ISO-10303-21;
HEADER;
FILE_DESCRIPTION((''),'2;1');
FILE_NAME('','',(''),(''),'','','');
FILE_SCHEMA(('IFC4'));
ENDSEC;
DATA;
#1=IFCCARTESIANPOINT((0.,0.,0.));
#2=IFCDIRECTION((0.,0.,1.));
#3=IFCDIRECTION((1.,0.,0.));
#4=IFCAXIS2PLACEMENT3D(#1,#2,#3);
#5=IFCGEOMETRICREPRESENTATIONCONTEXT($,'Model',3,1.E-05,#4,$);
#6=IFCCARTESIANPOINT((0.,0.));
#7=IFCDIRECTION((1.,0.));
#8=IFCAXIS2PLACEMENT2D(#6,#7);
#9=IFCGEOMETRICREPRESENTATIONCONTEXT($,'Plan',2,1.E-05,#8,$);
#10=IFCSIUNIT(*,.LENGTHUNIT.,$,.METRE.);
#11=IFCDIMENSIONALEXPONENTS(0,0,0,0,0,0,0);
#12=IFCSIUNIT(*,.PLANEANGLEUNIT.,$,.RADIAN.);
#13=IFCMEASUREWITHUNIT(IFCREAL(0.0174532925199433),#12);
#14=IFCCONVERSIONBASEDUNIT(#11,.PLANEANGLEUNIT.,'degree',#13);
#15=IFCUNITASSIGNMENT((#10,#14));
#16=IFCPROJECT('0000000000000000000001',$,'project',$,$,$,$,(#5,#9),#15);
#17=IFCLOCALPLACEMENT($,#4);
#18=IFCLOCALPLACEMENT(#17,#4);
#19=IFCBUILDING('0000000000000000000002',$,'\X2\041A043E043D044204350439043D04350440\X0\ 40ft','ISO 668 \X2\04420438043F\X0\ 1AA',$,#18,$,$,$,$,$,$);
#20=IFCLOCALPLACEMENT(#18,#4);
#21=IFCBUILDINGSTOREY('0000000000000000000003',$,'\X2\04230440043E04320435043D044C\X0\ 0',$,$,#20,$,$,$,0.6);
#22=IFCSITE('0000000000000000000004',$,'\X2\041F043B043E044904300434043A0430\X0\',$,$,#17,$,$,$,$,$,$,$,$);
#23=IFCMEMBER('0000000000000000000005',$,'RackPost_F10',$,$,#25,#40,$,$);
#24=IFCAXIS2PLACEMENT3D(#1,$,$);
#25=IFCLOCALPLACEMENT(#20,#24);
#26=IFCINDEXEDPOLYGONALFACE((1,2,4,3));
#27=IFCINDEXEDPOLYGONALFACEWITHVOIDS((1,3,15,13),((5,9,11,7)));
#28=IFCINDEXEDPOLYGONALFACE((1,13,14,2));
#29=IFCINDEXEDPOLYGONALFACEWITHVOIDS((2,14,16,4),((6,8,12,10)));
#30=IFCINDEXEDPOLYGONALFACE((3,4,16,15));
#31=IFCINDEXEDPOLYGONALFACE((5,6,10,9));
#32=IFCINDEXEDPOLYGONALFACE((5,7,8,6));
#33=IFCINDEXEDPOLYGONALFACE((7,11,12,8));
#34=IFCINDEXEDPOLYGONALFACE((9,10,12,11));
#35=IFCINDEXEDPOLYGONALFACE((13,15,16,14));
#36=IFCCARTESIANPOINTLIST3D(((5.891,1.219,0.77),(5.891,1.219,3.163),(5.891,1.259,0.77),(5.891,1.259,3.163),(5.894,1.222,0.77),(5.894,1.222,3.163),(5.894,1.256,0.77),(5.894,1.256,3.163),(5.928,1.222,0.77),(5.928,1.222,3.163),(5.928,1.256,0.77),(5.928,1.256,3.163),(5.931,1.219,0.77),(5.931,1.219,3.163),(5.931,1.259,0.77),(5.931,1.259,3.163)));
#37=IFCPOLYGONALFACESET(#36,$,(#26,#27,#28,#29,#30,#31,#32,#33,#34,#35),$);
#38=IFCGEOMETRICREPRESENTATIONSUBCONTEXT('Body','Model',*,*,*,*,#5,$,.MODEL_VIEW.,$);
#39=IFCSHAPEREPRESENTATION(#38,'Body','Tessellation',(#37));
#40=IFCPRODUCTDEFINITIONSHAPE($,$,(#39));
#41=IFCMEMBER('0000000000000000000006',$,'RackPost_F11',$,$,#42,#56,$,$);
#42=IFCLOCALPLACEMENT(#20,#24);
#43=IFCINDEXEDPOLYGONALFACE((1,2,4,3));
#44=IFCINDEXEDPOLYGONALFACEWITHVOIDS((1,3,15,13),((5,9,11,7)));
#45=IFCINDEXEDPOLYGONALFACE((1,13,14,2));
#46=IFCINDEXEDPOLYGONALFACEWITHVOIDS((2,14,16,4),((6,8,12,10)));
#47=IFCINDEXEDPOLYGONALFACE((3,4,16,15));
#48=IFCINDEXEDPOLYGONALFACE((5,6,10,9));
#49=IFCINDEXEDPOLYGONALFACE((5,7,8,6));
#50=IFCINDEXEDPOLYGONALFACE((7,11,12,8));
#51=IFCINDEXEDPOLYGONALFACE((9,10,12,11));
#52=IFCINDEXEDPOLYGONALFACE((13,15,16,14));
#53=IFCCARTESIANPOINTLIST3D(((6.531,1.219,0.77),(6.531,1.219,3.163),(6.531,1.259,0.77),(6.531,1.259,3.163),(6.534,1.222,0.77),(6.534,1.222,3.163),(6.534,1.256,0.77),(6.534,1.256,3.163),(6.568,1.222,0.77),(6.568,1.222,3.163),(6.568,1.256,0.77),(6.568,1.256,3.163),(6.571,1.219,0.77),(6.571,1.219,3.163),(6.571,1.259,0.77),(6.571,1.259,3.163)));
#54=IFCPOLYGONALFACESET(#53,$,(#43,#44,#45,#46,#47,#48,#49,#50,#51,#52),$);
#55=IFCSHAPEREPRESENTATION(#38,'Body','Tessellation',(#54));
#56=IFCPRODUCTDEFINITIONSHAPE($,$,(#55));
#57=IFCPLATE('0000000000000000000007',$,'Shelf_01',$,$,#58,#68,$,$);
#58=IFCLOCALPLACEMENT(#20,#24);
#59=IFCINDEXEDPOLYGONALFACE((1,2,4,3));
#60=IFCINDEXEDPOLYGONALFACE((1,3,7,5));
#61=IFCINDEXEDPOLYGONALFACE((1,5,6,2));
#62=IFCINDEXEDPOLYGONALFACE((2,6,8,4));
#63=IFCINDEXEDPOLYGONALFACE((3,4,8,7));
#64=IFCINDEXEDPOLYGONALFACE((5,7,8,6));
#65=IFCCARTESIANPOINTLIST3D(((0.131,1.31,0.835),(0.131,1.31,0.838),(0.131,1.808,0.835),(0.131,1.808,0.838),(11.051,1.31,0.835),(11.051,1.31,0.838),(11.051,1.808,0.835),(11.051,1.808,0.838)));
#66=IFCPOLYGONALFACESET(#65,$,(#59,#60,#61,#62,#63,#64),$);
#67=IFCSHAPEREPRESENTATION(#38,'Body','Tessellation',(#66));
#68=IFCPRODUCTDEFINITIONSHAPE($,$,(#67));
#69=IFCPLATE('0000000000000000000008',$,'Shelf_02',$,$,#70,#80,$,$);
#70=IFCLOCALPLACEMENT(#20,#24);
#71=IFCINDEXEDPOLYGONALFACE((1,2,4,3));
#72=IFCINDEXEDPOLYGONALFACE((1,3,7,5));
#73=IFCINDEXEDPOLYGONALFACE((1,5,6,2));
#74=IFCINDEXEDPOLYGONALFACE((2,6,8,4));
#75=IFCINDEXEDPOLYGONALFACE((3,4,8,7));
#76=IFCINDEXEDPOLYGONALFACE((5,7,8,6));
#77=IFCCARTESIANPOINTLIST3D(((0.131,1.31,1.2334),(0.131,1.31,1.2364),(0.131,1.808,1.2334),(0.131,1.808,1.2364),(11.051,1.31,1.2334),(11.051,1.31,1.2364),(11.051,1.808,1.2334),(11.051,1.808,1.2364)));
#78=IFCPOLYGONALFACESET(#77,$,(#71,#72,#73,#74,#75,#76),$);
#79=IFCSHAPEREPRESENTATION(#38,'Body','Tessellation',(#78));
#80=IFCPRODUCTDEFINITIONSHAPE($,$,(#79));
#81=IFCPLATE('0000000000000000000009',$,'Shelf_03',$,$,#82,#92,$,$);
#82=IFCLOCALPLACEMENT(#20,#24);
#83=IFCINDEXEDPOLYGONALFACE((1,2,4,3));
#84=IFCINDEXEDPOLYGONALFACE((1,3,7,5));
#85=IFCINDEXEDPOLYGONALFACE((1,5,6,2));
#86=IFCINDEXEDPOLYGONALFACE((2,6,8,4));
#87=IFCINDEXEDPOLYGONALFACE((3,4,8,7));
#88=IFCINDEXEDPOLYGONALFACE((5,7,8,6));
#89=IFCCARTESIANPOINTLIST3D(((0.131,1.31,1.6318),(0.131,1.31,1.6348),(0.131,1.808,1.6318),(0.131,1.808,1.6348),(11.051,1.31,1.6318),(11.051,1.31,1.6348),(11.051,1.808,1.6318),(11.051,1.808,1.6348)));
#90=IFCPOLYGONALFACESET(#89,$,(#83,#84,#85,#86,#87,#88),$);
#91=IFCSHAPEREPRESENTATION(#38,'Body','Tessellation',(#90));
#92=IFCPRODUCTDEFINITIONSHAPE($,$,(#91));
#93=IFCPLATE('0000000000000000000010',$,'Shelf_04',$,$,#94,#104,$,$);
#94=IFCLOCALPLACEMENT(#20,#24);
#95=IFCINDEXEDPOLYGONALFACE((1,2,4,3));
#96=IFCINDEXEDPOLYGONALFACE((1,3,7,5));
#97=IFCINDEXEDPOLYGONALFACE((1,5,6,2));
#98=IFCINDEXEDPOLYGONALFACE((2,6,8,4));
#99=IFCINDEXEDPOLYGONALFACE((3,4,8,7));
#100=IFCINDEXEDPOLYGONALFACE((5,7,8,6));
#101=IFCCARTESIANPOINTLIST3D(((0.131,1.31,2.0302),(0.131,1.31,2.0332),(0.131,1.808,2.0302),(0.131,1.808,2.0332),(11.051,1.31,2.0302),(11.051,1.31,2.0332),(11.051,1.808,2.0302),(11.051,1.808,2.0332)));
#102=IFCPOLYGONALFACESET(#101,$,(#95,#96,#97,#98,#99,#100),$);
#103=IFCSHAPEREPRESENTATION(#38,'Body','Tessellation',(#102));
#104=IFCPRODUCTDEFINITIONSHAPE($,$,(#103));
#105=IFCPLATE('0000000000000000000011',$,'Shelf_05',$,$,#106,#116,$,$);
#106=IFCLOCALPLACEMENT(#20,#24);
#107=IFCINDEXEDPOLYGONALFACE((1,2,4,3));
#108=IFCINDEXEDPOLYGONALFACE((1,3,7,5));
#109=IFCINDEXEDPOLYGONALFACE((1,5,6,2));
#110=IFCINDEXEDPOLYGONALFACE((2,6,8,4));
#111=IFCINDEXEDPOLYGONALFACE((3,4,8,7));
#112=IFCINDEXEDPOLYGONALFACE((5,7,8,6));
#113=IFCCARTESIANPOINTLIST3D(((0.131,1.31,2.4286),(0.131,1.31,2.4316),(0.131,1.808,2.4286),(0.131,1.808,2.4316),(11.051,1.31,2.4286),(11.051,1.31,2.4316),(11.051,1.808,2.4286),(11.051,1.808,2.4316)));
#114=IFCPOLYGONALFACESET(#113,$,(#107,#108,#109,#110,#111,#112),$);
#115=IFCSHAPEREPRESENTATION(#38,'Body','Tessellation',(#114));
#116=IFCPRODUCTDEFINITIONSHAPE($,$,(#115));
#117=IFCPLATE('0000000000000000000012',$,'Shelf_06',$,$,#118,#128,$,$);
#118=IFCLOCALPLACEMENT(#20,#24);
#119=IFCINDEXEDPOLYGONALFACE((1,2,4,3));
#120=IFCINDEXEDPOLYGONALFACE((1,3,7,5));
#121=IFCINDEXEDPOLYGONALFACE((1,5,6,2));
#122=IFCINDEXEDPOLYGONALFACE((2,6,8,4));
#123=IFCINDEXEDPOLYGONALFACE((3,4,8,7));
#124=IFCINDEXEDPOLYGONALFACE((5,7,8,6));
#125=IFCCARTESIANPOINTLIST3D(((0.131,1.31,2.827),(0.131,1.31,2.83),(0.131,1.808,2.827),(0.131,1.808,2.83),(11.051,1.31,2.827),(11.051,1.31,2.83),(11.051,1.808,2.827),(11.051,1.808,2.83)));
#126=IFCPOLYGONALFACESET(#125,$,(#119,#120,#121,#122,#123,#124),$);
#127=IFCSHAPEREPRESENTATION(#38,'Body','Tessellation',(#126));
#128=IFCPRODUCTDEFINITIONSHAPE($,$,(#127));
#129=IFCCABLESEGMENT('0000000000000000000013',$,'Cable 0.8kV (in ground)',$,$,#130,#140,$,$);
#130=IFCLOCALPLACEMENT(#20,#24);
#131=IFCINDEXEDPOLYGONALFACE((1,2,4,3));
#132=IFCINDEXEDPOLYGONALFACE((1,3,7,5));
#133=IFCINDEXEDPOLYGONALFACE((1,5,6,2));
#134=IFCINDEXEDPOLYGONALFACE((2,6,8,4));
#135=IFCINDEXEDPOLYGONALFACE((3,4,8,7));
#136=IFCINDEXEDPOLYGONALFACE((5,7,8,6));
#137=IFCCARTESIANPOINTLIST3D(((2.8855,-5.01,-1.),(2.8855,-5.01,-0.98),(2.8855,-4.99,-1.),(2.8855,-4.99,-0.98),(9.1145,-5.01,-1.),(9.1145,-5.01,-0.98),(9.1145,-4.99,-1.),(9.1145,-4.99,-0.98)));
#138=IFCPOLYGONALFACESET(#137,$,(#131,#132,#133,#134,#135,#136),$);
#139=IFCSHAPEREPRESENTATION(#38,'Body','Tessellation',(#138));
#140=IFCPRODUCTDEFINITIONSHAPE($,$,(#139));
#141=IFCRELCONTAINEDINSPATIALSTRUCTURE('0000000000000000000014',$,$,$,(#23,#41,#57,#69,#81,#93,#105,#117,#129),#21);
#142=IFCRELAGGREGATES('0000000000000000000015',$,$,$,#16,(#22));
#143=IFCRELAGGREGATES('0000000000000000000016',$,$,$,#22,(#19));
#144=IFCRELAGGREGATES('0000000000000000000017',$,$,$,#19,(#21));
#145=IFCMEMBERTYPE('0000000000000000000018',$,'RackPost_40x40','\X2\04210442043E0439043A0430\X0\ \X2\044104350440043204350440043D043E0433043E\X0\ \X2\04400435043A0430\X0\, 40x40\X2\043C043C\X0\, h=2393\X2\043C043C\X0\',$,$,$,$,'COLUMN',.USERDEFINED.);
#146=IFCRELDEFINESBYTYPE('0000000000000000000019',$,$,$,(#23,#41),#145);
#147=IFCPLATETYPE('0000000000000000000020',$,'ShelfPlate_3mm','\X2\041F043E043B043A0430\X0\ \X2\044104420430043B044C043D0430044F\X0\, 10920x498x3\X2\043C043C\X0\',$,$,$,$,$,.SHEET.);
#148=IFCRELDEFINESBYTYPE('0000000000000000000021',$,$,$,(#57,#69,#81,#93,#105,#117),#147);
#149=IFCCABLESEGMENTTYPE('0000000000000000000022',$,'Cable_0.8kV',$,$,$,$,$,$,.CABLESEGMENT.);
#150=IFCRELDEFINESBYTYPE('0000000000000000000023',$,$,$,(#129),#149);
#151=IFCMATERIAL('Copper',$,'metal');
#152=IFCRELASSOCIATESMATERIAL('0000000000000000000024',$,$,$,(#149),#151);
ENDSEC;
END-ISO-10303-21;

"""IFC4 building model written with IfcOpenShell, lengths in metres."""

from ifc_helpers import new_model, entity, si_unit, converted_unit, frame, origin_with_axes, origin_2d_with_axis, place, context, subcontext, project, spatial, rectangle, hollow_rectangle, extrude, material, type_object, element, save


model = new_model("IFC4")

# Units and contexts
model_context = context("Model", 3, precision=1e-05, world=origin_with_axes())
plan_context = context("Plan", 2, precision=1e-05, world=origin_2d_with_axis())
body_context = subcontext(model_context, "Body", "Model", "MODEL_VIEW")
ifc_project = project(units=[si_unit("LENGTHUNIT", "METRE"), converted_unit("PLANEANGLEUNIT", "degree", entity("IfcReal", 0.0174532925199433), si_unit("PLANEANGLEUNIT", "RADIAN"), dimensions=[0, 0, 0, 0, 0, 0, 0])], contexts=[model_context, plan_context])

# Site, building, storey
site_placement = place(None, origin_with_axes())
site = spatial("IfcSite", under=ifc_project, at=site_placement, Name="Площадка")
building_placement = place(site_placement, origin_with_axes())
building = spatial("IfcBuilding", under=site, at=building_placement, Name="Контейнер 40ft", Description="ISO 668 тип 1AA")
storey_placement = place(building_placement, origin_with_axes())
storey = spatial("IfcBuildingStorey", under=building, at=storey_placement, Name="Уровень 0", Elevation=0.6)

# Members
member_type = type_object("IfcMemberType", Name="RackPost_40x40", Description="Стойка серверного река, 40x40мм, h=2393мм", ElementType="COLUMN", PredefinedType="USERDEFINED")
for number, where, z_axis, x_axis, name in (
    (1, (5.911, 1.239, 0.77), (0.0, 0.0, 1.0), (1.0, 0.0, 0.0), "RackPost_F10"),
    (2, (6.551, 1.239, 0.77), (0.0, 0.0, 1.0), (1.0, 0.0, 0.0), "RackPost_F11"),
):
    element("IfcMember", number, at=place(storey_placement, frame(where, z_axis=z_axis, x_axis=x_axis)), inside=storey, type_object=member_type, Name=name, context=body_context, shape_type="SweptSolid", body=[
        extrude(hollow_rectangle(XDim=0.04, YDim=0.04, WallThickness=0.003), origin_with_axes(), (0.0, 0.0, 1.0), 2.393),
    ])

# Plates
plate_type = type_object("IfcPlateType", Name="ShelfPlate_3mm", Description="Полка стальная, 10920x498x3мм", PredefinedType="SHEET")
for number, where, z_axis, x_axis, name in (
    (3, (5.591, 1.559, 0.835), (0.0, 0.0, 1.0), (1.0, 0.0, 0.0), "Shelf_01"),
    (4, (5.591, 1.559, 1.2334), (0.0, 0.0, 1.0), (1.0, 0.0, 0.0), "Shelf_02"),
    (5, (5.591, 1.559, 1.6318), (0.0, 0.0, 1.0), (1.0, 0.0, 0.0), "Shelf_03"),
    (6, (5.591, 1.559, 2.0302), (0.0, 0.0, 1.0), (1.0, 0.0, 0.0), "Shelf_04"),
    (7, (5.591, 1.559, 2.4286), (0.0, 0.0, 1.0), (1.0, 0.0, 0.0), "Shelf_05"),
    (8, (5.591, 1.559, 2.827), (0.0, 0.0, 1.0), (1.0, 0.0, 0.0), "Shelf_06"),
):
    element("IfcPlate", number, at=place(storey_placement, frame(where, z_axis=z_axis, x_axis=x_axis)), inside=storey, type_object=plate_type, Name=name, context=body_context, shape_type="SweptSolid", body=[
        extrude(rectangle(XDim=10.92, YDim=0.498), origin_with_axes(), (0.0, 0.0, 1.0), 0.003),
    ])

# Cable segment
ifc_material = material(Name="Copper", Category="metal")
cable_segment_type = type_object("IfcCableSegmentType", Name="Cable_0.8kV", PredefinedType="CABLESEGMENT", material=ifc_material)
cable_segment_placement = place(storey_placement, frame((6.0, -5.0, -1.0), z_axis=(0.0, 0.0, 1.0), x_axis=(1.0, 0.0, 0.0)))
element("IfcCableSegment", 9, at=cable_segment_placement, inside=storey, type_object=cable_segment_type, Name="Cable 0.8kV (in ground)", context=body_context, shape_type="SweptSolid", body=[
    extrude(rectangle(XDim=6.229, YDim=0.02), None, (0.0, 0.0, 1.0), 0.02),
])

save(model, "model.ifc")
